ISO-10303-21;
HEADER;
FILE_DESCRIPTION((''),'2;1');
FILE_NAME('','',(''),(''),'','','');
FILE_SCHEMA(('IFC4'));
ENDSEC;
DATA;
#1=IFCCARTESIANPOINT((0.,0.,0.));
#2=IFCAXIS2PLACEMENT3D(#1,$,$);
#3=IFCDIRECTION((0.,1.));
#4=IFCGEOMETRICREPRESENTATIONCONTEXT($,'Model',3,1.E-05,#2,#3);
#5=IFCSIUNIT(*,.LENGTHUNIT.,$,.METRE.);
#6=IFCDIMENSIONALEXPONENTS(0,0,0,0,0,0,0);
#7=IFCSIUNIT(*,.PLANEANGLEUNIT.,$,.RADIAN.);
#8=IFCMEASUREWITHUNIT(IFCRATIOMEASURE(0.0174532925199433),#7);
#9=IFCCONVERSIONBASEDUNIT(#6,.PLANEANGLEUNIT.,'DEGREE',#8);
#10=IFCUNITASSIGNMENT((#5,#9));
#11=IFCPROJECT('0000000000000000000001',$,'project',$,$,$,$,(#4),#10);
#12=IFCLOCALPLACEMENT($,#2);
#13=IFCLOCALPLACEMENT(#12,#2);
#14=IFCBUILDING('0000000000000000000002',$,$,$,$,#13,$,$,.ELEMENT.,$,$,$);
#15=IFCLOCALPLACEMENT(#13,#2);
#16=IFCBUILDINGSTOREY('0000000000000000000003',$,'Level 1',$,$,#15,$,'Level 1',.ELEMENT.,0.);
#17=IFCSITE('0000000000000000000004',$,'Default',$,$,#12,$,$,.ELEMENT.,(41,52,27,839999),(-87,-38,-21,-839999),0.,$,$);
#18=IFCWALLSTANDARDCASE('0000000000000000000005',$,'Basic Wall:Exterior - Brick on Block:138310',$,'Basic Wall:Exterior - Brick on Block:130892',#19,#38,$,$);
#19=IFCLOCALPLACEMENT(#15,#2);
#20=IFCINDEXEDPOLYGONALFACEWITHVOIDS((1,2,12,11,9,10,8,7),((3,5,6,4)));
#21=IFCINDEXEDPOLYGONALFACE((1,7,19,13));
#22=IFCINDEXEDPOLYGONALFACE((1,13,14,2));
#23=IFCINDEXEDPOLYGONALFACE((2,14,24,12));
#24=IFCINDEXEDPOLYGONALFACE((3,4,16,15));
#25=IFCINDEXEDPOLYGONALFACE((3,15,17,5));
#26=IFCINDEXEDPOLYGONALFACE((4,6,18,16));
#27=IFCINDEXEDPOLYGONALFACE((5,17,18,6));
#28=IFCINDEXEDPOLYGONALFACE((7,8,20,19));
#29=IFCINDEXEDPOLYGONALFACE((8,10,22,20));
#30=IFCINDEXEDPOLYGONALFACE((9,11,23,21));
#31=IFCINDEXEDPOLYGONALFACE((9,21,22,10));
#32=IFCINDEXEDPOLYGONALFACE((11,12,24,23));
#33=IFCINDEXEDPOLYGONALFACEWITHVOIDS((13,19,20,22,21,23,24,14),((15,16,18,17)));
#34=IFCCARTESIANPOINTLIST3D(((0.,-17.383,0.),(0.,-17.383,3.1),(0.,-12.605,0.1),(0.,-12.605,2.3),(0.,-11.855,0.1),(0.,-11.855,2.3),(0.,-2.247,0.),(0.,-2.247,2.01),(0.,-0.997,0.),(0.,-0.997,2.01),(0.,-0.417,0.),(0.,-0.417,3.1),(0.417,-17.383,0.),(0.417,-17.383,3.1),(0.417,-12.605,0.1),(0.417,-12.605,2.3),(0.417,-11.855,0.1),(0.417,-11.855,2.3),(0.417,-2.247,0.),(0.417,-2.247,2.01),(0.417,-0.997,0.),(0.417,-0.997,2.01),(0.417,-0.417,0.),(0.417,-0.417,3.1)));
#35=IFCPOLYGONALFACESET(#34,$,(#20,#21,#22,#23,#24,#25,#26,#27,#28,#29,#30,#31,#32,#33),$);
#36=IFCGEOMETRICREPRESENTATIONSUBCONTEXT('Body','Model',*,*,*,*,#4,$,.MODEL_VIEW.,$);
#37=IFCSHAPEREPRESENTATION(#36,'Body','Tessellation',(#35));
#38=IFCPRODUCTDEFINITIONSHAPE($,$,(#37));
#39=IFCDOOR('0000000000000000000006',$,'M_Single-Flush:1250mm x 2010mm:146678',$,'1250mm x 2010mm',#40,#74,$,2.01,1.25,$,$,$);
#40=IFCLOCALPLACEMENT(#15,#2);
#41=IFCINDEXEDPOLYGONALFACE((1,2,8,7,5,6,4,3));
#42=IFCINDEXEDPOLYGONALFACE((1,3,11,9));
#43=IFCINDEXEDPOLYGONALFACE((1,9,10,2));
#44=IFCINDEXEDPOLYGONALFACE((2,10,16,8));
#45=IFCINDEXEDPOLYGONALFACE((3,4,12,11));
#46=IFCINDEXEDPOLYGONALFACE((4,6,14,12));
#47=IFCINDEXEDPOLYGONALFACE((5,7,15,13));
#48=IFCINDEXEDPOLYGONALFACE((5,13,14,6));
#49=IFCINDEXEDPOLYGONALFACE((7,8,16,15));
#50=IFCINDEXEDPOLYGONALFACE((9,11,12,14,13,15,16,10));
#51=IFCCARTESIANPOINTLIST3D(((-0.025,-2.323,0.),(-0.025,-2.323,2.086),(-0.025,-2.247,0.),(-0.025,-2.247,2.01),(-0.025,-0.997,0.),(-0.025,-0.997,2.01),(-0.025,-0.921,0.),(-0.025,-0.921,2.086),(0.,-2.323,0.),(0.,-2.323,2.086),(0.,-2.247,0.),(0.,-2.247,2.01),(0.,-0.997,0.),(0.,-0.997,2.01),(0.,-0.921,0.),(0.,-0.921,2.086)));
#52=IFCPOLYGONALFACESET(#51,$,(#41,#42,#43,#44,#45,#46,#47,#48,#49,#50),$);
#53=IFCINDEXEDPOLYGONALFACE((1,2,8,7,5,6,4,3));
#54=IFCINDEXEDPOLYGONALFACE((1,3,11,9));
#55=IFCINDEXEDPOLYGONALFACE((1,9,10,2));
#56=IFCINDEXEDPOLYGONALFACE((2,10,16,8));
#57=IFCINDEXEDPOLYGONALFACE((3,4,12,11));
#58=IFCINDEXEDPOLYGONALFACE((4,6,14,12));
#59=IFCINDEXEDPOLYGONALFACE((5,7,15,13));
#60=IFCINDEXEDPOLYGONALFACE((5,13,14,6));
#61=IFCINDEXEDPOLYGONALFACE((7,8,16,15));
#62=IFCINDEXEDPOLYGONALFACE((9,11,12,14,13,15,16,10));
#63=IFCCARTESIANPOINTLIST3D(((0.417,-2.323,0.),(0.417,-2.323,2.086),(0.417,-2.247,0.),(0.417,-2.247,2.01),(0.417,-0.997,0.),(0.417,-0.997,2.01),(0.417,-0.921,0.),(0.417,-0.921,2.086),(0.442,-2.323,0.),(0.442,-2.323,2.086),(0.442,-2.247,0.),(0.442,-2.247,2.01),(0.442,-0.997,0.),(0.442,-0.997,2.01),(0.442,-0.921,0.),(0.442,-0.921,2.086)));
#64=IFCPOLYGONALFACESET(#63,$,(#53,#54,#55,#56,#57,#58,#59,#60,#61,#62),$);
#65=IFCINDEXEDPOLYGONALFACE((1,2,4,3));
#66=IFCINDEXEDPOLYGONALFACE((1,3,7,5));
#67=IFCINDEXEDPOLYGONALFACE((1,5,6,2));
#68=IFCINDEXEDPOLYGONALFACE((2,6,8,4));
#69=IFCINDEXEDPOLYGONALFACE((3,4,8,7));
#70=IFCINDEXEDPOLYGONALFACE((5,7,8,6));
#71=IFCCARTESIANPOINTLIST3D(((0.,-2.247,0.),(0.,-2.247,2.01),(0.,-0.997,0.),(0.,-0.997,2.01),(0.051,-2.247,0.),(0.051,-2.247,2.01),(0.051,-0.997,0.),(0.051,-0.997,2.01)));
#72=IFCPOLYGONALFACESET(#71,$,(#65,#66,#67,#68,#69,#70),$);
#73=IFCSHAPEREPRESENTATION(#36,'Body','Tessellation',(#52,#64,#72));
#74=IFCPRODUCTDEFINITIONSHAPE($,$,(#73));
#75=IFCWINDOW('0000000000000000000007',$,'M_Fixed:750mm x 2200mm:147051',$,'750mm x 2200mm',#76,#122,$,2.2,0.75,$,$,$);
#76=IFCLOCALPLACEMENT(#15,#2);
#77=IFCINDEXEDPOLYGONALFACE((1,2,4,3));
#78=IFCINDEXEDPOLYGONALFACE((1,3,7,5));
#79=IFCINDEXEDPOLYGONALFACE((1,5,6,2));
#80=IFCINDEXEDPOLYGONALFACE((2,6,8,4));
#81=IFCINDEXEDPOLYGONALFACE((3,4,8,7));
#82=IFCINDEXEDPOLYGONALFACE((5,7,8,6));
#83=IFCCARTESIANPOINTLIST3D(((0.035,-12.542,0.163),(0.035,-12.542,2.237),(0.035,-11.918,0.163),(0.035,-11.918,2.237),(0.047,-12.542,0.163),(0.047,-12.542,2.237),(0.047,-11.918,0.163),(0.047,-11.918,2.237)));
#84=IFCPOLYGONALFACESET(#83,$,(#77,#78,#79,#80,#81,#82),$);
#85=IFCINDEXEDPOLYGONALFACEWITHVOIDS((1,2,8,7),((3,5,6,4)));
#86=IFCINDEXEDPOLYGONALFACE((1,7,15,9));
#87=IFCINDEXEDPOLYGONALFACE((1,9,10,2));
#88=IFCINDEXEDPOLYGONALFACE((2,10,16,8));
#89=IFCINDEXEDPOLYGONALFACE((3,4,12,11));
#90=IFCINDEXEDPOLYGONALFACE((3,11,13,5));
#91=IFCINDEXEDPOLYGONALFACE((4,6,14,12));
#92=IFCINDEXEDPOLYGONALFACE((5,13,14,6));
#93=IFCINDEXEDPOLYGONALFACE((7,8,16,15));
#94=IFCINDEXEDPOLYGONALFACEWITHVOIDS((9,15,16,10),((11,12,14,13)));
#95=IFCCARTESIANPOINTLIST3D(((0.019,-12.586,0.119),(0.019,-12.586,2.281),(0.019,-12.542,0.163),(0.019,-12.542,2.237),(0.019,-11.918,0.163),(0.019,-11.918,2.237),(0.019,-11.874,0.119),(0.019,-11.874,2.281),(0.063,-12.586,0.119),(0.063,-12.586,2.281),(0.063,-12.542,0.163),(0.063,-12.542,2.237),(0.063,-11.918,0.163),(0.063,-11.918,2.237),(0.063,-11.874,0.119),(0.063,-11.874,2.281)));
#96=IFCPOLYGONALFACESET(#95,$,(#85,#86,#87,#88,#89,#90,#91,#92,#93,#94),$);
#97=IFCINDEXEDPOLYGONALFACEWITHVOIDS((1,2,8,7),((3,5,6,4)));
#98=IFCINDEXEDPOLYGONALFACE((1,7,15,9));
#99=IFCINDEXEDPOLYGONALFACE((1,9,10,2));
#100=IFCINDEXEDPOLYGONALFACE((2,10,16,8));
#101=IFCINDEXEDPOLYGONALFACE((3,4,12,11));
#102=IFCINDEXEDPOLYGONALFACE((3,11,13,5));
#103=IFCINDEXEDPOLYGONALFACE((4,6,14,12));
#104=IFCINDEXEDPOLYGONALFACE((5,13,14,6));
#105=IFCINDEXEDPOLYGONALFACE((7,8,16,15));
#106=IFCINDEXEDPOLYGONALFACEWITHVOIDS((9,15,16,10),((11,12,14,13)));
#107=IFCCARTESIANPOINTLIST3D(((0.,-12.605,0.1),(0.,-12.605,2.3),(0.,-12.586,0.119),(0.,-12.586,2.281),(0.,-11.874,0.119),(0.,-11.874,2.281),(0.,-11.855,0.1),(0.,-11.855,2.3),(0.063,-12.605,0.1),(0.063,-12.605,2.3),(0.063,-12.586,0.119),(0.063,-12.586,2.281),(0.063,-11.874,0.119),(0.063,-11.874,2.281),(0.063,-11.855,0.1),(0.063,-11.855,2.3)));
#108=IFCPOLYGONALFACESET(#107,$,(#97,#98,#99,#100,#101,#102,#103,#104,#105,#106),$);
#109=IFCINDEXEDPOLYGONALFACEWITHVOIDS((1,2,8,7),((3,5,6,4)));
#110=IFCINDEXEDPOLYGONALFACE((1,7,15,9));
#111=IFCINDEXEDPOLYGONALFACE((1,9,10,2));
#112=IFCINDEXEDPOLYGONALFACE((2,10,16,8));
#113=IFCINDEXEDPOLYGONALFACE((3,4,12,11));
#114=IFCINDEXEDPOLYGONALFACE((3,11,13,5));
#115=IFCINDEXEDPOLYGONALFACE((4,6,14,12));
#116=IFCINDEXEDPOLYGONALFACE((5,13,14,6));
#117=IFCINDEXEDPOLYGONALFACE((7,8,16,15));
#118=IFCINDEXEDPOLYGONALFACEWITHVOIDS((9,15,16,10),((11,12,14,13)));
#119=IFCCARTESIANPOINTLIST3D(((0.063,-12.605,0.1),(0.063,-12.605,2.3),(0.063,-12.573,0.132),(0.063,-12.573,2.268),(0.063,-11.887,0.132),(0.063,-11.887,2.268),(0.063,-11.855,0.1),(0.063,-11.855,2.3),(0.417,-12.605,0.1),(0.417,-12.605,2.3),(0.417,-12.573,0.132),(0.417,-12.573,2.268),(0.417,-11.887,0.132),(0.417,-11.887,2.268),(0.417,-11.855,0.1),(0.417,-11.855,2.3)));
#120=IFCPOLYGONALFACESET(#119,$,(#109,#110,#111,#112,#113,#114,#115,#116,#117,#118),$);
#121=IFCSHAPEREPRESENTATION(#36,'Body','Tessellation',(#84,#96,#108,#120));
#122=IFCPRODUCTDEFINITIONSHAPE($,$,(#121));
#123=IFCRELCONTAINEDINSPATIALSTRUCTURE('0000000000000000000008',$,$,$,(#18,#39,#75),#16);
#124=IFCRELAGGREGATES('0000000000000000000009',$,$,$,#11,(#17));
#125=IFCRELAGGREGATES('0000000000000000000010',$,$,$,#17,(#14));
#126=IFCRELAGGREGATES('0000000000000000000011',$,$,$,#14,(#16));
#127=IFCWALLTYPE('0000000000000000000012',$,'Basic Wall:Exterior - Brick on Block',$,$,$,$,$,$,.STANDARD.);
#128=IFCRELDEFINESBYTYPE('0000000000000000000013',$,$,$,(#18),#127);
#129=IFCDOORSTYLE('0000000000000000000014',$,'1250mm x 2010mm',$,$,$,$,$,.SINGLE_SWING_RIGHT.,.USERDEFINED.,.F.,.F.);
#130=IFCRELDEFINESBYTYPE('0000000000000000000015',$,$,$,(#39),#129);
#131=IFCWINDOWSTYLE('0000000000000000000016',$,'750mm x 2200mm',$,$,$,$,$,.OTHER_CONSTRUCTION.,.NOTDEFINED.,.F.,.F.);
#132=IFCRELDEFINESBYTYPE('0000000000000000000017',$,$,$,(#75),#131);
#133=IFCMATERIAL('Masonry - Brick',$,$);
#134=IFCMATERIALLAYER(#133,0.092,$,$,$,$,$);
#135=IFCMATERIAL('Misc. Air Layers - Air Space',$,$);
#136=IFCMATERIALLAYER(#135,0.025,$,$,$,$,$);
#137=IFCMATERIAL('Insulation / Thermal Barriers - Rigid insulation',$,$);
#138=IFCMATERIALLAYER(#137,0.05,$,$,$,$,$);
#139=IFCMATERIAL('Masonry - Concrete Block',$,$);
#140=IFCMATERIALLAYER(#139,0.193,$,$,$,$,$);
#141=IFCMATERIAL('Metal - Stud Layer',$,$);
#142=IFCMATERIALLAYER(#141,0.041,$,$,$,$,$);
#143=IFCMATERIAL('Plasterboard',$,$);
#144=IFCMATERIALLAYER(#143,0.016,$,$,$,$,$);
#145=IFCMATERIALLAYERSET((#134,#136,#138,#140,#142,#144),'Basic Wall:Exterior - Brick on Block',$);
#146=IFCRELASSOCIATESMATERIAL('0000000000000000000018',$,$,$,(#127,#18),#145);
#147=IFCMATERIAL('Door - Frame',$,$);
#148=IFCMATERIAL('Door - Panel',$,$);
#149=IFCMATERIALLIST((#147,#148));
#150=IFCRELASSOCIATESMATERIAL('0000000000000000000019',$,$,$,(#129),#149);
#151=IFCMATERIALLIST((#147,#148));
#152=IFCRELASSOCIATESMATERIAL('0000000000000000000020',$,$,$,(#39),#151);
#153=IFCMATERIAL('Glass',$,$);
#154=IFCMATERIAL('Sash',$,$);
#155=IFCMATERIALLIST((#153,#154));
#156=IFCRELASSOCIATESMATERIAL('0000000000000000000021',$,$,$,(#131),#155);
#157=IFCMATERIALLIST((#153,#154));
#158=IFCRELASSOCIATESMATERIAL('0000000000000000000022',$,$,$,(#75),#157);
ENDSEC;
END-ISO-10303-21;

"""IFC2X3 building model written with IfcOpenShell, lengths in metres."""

from ifc_helpers import new_model, entity, si_unit, converted_unit, direction, frame, frame_2d, origin, origin_2d_with_axis, place, context, subcontext, project, spatial, polyline, rectangle, outline, extrude, source, transform, mapped, material, material_list, layer, layer_set, layer_usage, type_object, type_shapes, element, fill, save


model = new_model("IFC2X3")

# Units and contexts
model_context = context("Model", 3, precision=1e-05, world=origin(), true_north=direction((0.0, 1.0)))
body_context = subcontext(model_context, "Body", "Model", "MODEL_VIEW")
ifc_project = project(units=[si_unit("LENGTHUNIT", "METRE"), converted_unit("PLANEANGLEUNIT", "DEGREE", entity("IfcRatioMeasure", 0.0174532925199433), si_unit("PLANEANGLEUNIT", "RADIAN"), dimensions=[0, 0, 0, 0, 0, 0, 0])], contexts=[model_context])

# Site, building, storey
site_placement = place(None, origin())
site = spatial("IfcSite", under=ifc_project, at=site_placement, Name="Default", CompositionType="ELEMENT", RefLatitude=(41, 52, 27, 839999), RefLongitude=(-87, -38, -21, -839999), RefElevation=0.0)
building_placement = place(site_placement, origin())
building = spatial("IfcBuilding", under=site, at=building_placement, CompositionType="ELEMENT")
storey_placement = place(building_placement, origin())
storey = spatial("IfcBuildingStorey", under=building, at=storey_placement, Name="Level 1", LongName="Level 1", CompositionType="ELEMENT", Elevation=0.0)

# Shared definitions
ifc_material_1 = material(Name="Masonry - Brick")
ifc_layer_1 = layer(ifc_material_1, 0.092)
ifc_material_2 = material(Name="Misc. Air Layers - Air Space")
ifc_layer_2 = layer(ifc_material_2, 0.025)
ifc_material_3 = material(Name="Insulation / Thermal Barriers - Rigid insulation")
ifc_layer_3 = layer(ifc_material_3, 0.05)
ifc_material_4 = material(Name="Masonry - Concrete Block")
ifc_layer_4 = layer(ifc_material_4, 0.193)
ifc_material_5 = material(Name="Metal - Stud Layer")
ifc_layer_5 = layer(ifc_material_5, 0.041)
ifc_material_6 = material(Name="Plasterboard")
ifc_layer_6 = layer(ifc_material_6, 0.016)
ifc_layer_set_1 = layer_set([ifc_layer_1, ifc_layer_2, ifc_layer_3, ifc_layer_4, ifc_layer_5, ifc_layer_6], Name="Basic Wall:Exterior - Brick on Block")
wall_type_1 = type_object("IfcWallType", Name="Basic Wall:Exterior - Brick on Block", PredefinedType="STANDARD", material=ifc_layer_set_1)
ifc_material_7 = material(Name="Glass")
ifc_material_8 = material(Name="Sash")
ifc_material_9 = material(Name="Door - Frame")
ifc_material_10 = material(Name="Door - Panel")

# Wall, openings, door, window
ifc_layer_usage_1 = layer_usage(ifc_layer_set_1, "AXIS2", "NEGATIVE", 0.2085)
wall_1_placement = place(storey_placement, frame((0.2085, -17.383, 0.0), z_axis=(0.0, 0.0, 1.0), x_axis=(0.0, 1.0, 0.0)))
wall_1 = element("IfcWallStandardCase", 1, at=wall_1_placement, inside=storey, type_object=wall_type_1, material=ifc_layer_usage_1, Name="Basic Wall:Exterior - Brick on Block:138310", ObjectType="Basic Wall:Exterior - Brick on Block:130892", context=body_context, shape_type="SweptSolid", body=[
    extrude(rectangle(XDim=16.966, YDim=0.417, at=frame_2d((8.483, 0.0), x_axis=(-1.0, 0.0))), origin(), (0.0, 0.0, 1.0), 3.1),
])
opening_1_placement = place(wall_1_placement, frame((15.136, -0.2085, 0.0)))
opening_1 = element("IfcOpeningElement", 2, at=opening_1_placement, cuts=wall_1, ObjectType="Opening", context=body_context, shape_type="SweptSolid", body=[
    extrude(rectangle(XDim=1.25, YDim=2.01, at=frame_2d((1.005, 0.625), x_axis=(0.0, 1.0))), frame((0.0, 0.0, 0.0), z_axis=(0.0, 1.0, 0.0), x_axis=(0.0, 0.0, 1.0)), (0.0, 0.0, 1.0), 0.417),
])
opening_2_placement = place(wall_1_placement, frame((4.778, -0.2085, 0.1)))
opening_2 = element("IfcOpeningElement", 3, at=opening_2_placement, cuts=wall_1, ObjectType="Opening", context=body_context, shape_type="SweptSolid", body=[
    extrude(rectangle(XDim=2.2, YDim=0.75, at=frame_2d((1.1, 0.375), x_axis=(1.0, 0.0))), frame((0.0, 0.0, 0.0), z_axis=(0.0, 1.0, 0.0), x_axis=(0.0, 0.0, 1.0)), (0.0, 0.0, 1.0), 0.417),
])
ifc_material_list_1 = material_list([ifc_material_9, ifc_material_10])
ifc_material_list_2 = material_list([ifc_material_9, ifc_material_10])
door_style_1 = type_object("IfcDoorStyle", Name="1250mm x 2010mm", ConstructionType="USERDEFINED", OperationType="SINGLE_SWING_RIGHT", ParameterTakesPrecedence=False, Sizeable=False, material=ifc_material_list_2)
shared_shape_1 = source(origin(), body_context, "Body", "SweptSolid", [
    extrude(outline(polyline([(-0.701, -1.062), (0.701, -1.062), (0.701, 1.024), (0.625, 1.024), (0.625, -0.986), (-0.625, -0.986), (-0.625, 1.024), (-0.701, 1.024), (-0.701, -1.062)])), frame((0.625, 0.417, 1.024), z_axis=(0.0, 1.0, 0.0), x_axis=(1.0, 0.0, 0.0)), (0.0, 0.0, 1.0), 0.025),
    extrude(outline(polyline([(-1.062, -0.701), (1.024, -0.701), (1.024, -0.625), (-0.986, -0.625), (-0.986, 0.625), (1.024, 0.625), (1.024, 0.701), (-1.062, 0.701), (-1.062, -0.701)])), frame((0.625, -0.025, 1.024), z_axis=(0.0, 1.0, 0.0), x_axis=(0.0, 0.0, -1.0)), (0.0, 0.0, 1.0), 0.025),
    extrude(rectangle(XDim=0.051, YDim=1.25, at=frame_2d((0.0, 0.0), x_axis=(1.0, 0.0))), frame((0.625, 0.3915, 0.0), z_axis=(0.0, 0.0, 1.0), x_axis=(0.0, 1.0, 0.0)), (0.0, 0.0, 1.0), 2.01),
])
type_shapes(door_style_1, [shared_shape_1])
door_1_placement = place(opening_1_placement, origin())
door_1 = element("IfcDoor", 4, at=door_1_placement, inside=storey, type_object=door_style_1, material=ifc_material_list_1, Name="M_Single-Flush:1250mm x 2010mm:146678", ObjectType="1250mm x 2010mm", OverallHeight=2.01, OverallWidth=1.25, context=body_context, shape_type="MappedRepresentation", body=[
    mapped(shared_shape_1, transform((0.0, 0.0, 0.0), scale=1.0)),
])
fill(opening_1, door_1)
ifc_material_list_3 = material_list([ifc_material_7, ifc_material_8])
ifc_material_list_4 = material_list([ifc_material_7, ifc_material_8])
window_style_1 = type_object("IfcWindowStyle", Name="750mm x 2200mm", ConstructionType="OTHER_CONSTRUCTION", OperationType="NOTDEFINED", ParameterTakesPrecedence=False, Sizeable=False, material=ifc_material_list_4)
shared_shape_2 = source(origin(), body_context, "Body", "SweptSolid", [
    extrude(rectangle(XDim=0.012, YDim=0.624, at=origin_2d_with_axis()), frame((0.375, 0.376, 0.063), z_axis=(0.0, 0.0, 1.0), x_axis=(0.0, -1.0, 0.0)), (0.0, 0.0, 1.0), 2.074),
    extrude(outline(polyline([(-0.356, -1.081), (0.356, -1.081), (0.356, 1.081), (-0.356, 1.081), (-0.356, -1.081)]), holes=[polyline([(-0.312, -1.037), (-0.312, 1.037), (0.312, 1.037), (0.312, -1.037), (-0.312, -1.037)])]), frame((0.375, 0.354, 1.1), z_axis=(0.0, 1.0, 0.0), x_axis=(1.0, 0.0, 0.0)), (0.0, 0.0, 1.0), 0.044),
    extrude(outline(polyline([(-0.375, -1.1), (0.375, -1.1), (0.375, 1.1), (-0.375, 1.1), (-0.375, -1.1)]), holes=[polyline([(-0.356, -1.081), (-0.356, 1.081), (0.356, 1.081), (0.356, -1.081), (-0.356, -1.081)])]), frame((0.375, 0.354, 1.1), z_axis=(0.0, 1.0, 0.0), x_axis=(1.0, 0.0, 0.0)), (0.0, 0.0, 1.0), 0.063),
    extrude(outline(polyline([(-0.375, -1.1), (0.375, -1.1), (0.375, 1.1), (-0.375, 1.1), (-0.375, -1.1)]), holes=[polyline([(-0.343, -1.068), (-0.343, 1.068), (0.343, 1.068), (0.343, -1.068), (-0.343, -1.068)])]), frame((0.375, 0.0, 1.1), z_axis=(0.0, 1.0, 0.0), x_axis=(1.0, 0.0, 0.0)), (0.0, 0.0, 1.0), 0.354),
])
type_shapes(window_style_1, [shared_shape_2])
window_1_placement = place(opening_2_placement, origin())
window_1 = element("IfcWindow", 5, at=window_1_placement, inside=storey, type_object=window_style_1, material=ifc_material_list_3, Name="M_Fixed:750mm x 2200mm:147051", ObjectType="750mm x 2200mm", OverallHeight=2.2, OverallWidth=0.75, context=body_context, shape_type="MappedRepresentation", body=[
    mapped(shared_shape_2, transform((0.0, 0.0, 0.0), scale=1.0)),
])
fill(opening_2, window_1)

save(model, "model.ifc")
